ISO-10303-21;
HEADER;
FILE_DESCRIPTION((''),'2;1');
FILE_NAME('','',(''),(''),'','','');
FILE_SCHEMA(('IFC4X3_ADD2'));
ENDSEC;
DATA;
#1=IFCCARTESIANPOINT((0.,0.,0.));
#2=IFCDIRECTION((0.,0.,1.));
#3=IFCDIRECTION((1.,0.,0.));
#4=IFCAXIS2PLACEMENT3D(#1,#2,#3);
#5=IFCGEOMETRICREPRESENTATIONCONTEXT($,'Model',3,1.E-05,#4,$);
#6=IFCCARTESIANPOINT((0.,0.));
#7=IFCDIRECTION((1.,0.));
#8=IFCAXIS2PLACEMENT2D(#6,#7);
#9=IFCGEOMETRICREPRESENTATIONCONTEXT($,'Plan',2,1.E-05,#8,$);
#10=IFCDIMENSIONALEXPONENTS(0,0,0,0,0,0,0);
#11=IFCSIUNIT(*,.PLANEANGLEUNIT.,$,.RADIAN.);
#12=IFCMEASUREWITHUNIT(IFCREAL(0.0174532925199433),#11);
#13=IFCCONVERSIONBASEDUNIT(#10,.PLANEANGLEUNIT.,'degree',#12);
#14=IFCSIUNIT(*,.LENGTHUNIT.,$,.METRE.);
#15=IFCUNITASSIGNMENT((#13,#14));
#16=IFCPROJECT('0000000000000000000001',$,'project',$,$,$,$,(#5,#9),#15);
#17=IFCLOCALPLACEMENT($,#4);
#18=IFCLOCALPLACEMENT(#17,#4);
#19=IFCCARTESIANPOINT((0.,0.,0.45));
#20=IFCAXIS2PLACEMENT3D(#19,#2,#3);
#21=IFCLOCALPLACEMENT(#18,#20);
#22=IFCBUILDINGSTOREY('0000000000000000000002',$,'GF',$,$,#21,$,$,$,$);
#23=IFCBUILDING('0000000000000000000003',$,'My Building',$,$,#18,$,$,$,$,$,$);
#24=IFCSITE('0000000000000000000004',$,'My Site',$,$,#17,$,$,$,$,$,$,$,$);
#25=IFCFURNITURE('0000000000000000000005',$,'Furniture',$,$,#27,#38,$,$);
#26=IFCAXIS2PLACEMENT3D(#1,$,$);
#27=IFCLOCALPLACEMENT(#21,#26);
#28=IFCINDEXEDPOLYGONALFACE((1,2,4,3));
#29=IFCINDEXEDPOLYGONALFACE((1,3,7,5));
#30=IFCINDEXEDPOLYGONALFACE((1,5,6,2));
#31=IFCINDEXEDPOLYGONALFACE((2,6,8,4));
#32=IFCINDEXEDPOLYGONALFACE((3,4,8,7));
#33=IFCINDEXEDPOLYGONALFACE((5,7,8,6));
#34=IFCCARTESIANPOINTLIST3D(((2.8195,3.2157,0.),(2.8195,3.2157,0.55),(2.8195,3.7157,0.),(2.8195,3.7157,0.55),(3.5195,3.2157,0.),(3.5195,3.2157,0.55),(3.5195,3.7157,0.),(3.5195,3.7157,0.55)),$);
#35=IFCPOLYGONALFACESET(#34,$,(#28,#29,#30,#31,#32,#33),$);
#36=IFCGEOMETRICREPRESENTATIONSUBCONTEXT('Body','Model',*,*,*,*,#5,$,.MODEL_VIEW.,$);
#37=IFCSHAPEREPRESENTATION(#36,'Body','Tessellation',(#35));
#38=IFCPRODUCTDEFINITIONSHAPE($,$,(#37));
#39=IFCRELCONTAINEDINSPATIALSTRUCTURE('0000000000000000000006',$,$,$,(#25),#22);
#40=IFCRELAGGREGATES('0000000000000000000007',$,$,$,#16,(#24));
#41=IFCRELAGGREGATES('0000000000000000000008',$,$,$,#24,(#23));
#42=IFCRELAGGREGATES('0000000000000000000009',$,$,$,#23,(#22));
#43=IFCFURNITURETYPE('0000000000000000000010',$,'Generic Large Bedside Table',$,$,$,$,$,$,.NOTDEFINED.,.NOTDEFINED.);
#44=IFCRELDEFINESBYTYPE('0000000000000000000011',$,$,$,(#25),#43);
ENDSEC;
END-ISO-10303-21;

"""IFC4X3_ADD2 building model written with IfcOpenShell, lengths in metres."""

from ifc_helpers import new_model, entity, si_unit, converted_unit, frame, origin_with_axes, origin_2d_with_axis, place, context, subcontext, project, spatial, line, indexed_curve, outline, extrude, shape, source, transform, mapped, type_object, type_shapes, element, save


model = new_model("IFC4X3_ADD2")

# Units and contexts
model_context = context("Model", 3, precision=1e-05, world=origin_with_axes())
plan_context = context("Plan", 2, precision=1e-05, world=origin_2d_with_axis())
body_context_1 = subcontext(model_context, "Body", "Model", "MODEL_VIEW")
body_context_2 = subcontext(plan_context, "Body", "Plan", "PLAN_VIEW")
ifc_project = project(units=[converted_unit("PLANEANGLEUNIT", "degree", entity("IfcReal", 0.0174532925199433), si_unit("PLANEANGLEUNIT", "RADIAN"), dimensions=[0, 0, 0, 0, 0, 0, 0]), si_unit("LENGTHUNIT", "METRE")], contexts=[model_context, plan_context])

# Site, building, storey
site_placement = place(None, origin_with_axes())
site = spatial("IfcSite", under=ifc_project, at=site_placement, Name="My Site")
building_placement = place(site_placement, origin_with_axes())
building = spatial("IfcBuilding", under=site, at=building_placement, Name="My Building")
storey_placement = place(building_placement, frame((0.0, 0.0, 0.45), z_axis=(0.0, 0.0, 1.0), x_axis=(1.0, 0.0, 0.0)))
storey = spatial("IfcBuildingStorey", under=building, at=storey_placement, Name="GF")

# Furniture
furniture_type_1 = type_object("IfcFurnitureType", Name="Generic Large Bedside Table", AssemblyPlace="NOTDEFINED", PredefinedType="NOTDEFINED")
shared_shape_1 = source(origin_with_axes(), body_context_1, "Body", "SweptSolid", [
    extrude(outline(indexed_curve([(0.0, 0.0), (0.7, 0.0), (0.7, 0.5), (0.0, 0.5)], segments=[line(1, 2, 3, 4, 1)])), frame((-0.35, -0.25, 0.0), z_axis=(0.0, 0.0, 1.0), x_axis=(1.0, 0.0, 0.0)), (0.0, 0.0, 1.0), 0.55),
])
shared_shape_2 = source(origin_with_axes(), body_context_2, "Body", "Curve2D", [
    entity("IfcIndexedPolyCurve", entity("IfcCartesianPointList2D", [[-0.35, -0.25], [0.35, -0.25], [0.35, 0.25], [-0.35, 0.25]]), [entity("IfcLineIndex", [1, 2, 3, 4, 1])]),
])
type_shapes(furniture_type_1, [shared_shape_1, shared_shape_2])
for number, where, z_axis, x_axis, name in (
    (1, (3.1695, 3.4657, 0.0), (0.0, 0.0, 1.0), (1.0, 0.0, 0.0), "Furniture"),
):
    element("IfcFurniture", number, at=place(storey_placement, frame(where, z_axis=z_axis, x_axis=x_axis)), inside=storey, type_object=furniture_type_1, Name=name, shapes=[
        shape(body_context_1, "Body", "MappedRepresentation", [mapped(shared_shape_1, transform((0.0, 0.0, 0.0), x_axis=(1.0, 0.0, 0.0), y_axis=(0.0, 1.0, 0.0), z_axis=(0.0, 0.0, 1.0), scale=1.0))]),
        shape(body_context_2, "Body", "MappedRepresentation", [mapped(shared_shape_2, transform((0.0, 0.0, 0.0), x_axis=(1.0, 0.0, 0.0), y_axis=(0.0, 1.0, 0.0), z_axis=(0.0, 0.0, 1.0), scale=1.0))]),
    ])

save(model, "model.ifc")
